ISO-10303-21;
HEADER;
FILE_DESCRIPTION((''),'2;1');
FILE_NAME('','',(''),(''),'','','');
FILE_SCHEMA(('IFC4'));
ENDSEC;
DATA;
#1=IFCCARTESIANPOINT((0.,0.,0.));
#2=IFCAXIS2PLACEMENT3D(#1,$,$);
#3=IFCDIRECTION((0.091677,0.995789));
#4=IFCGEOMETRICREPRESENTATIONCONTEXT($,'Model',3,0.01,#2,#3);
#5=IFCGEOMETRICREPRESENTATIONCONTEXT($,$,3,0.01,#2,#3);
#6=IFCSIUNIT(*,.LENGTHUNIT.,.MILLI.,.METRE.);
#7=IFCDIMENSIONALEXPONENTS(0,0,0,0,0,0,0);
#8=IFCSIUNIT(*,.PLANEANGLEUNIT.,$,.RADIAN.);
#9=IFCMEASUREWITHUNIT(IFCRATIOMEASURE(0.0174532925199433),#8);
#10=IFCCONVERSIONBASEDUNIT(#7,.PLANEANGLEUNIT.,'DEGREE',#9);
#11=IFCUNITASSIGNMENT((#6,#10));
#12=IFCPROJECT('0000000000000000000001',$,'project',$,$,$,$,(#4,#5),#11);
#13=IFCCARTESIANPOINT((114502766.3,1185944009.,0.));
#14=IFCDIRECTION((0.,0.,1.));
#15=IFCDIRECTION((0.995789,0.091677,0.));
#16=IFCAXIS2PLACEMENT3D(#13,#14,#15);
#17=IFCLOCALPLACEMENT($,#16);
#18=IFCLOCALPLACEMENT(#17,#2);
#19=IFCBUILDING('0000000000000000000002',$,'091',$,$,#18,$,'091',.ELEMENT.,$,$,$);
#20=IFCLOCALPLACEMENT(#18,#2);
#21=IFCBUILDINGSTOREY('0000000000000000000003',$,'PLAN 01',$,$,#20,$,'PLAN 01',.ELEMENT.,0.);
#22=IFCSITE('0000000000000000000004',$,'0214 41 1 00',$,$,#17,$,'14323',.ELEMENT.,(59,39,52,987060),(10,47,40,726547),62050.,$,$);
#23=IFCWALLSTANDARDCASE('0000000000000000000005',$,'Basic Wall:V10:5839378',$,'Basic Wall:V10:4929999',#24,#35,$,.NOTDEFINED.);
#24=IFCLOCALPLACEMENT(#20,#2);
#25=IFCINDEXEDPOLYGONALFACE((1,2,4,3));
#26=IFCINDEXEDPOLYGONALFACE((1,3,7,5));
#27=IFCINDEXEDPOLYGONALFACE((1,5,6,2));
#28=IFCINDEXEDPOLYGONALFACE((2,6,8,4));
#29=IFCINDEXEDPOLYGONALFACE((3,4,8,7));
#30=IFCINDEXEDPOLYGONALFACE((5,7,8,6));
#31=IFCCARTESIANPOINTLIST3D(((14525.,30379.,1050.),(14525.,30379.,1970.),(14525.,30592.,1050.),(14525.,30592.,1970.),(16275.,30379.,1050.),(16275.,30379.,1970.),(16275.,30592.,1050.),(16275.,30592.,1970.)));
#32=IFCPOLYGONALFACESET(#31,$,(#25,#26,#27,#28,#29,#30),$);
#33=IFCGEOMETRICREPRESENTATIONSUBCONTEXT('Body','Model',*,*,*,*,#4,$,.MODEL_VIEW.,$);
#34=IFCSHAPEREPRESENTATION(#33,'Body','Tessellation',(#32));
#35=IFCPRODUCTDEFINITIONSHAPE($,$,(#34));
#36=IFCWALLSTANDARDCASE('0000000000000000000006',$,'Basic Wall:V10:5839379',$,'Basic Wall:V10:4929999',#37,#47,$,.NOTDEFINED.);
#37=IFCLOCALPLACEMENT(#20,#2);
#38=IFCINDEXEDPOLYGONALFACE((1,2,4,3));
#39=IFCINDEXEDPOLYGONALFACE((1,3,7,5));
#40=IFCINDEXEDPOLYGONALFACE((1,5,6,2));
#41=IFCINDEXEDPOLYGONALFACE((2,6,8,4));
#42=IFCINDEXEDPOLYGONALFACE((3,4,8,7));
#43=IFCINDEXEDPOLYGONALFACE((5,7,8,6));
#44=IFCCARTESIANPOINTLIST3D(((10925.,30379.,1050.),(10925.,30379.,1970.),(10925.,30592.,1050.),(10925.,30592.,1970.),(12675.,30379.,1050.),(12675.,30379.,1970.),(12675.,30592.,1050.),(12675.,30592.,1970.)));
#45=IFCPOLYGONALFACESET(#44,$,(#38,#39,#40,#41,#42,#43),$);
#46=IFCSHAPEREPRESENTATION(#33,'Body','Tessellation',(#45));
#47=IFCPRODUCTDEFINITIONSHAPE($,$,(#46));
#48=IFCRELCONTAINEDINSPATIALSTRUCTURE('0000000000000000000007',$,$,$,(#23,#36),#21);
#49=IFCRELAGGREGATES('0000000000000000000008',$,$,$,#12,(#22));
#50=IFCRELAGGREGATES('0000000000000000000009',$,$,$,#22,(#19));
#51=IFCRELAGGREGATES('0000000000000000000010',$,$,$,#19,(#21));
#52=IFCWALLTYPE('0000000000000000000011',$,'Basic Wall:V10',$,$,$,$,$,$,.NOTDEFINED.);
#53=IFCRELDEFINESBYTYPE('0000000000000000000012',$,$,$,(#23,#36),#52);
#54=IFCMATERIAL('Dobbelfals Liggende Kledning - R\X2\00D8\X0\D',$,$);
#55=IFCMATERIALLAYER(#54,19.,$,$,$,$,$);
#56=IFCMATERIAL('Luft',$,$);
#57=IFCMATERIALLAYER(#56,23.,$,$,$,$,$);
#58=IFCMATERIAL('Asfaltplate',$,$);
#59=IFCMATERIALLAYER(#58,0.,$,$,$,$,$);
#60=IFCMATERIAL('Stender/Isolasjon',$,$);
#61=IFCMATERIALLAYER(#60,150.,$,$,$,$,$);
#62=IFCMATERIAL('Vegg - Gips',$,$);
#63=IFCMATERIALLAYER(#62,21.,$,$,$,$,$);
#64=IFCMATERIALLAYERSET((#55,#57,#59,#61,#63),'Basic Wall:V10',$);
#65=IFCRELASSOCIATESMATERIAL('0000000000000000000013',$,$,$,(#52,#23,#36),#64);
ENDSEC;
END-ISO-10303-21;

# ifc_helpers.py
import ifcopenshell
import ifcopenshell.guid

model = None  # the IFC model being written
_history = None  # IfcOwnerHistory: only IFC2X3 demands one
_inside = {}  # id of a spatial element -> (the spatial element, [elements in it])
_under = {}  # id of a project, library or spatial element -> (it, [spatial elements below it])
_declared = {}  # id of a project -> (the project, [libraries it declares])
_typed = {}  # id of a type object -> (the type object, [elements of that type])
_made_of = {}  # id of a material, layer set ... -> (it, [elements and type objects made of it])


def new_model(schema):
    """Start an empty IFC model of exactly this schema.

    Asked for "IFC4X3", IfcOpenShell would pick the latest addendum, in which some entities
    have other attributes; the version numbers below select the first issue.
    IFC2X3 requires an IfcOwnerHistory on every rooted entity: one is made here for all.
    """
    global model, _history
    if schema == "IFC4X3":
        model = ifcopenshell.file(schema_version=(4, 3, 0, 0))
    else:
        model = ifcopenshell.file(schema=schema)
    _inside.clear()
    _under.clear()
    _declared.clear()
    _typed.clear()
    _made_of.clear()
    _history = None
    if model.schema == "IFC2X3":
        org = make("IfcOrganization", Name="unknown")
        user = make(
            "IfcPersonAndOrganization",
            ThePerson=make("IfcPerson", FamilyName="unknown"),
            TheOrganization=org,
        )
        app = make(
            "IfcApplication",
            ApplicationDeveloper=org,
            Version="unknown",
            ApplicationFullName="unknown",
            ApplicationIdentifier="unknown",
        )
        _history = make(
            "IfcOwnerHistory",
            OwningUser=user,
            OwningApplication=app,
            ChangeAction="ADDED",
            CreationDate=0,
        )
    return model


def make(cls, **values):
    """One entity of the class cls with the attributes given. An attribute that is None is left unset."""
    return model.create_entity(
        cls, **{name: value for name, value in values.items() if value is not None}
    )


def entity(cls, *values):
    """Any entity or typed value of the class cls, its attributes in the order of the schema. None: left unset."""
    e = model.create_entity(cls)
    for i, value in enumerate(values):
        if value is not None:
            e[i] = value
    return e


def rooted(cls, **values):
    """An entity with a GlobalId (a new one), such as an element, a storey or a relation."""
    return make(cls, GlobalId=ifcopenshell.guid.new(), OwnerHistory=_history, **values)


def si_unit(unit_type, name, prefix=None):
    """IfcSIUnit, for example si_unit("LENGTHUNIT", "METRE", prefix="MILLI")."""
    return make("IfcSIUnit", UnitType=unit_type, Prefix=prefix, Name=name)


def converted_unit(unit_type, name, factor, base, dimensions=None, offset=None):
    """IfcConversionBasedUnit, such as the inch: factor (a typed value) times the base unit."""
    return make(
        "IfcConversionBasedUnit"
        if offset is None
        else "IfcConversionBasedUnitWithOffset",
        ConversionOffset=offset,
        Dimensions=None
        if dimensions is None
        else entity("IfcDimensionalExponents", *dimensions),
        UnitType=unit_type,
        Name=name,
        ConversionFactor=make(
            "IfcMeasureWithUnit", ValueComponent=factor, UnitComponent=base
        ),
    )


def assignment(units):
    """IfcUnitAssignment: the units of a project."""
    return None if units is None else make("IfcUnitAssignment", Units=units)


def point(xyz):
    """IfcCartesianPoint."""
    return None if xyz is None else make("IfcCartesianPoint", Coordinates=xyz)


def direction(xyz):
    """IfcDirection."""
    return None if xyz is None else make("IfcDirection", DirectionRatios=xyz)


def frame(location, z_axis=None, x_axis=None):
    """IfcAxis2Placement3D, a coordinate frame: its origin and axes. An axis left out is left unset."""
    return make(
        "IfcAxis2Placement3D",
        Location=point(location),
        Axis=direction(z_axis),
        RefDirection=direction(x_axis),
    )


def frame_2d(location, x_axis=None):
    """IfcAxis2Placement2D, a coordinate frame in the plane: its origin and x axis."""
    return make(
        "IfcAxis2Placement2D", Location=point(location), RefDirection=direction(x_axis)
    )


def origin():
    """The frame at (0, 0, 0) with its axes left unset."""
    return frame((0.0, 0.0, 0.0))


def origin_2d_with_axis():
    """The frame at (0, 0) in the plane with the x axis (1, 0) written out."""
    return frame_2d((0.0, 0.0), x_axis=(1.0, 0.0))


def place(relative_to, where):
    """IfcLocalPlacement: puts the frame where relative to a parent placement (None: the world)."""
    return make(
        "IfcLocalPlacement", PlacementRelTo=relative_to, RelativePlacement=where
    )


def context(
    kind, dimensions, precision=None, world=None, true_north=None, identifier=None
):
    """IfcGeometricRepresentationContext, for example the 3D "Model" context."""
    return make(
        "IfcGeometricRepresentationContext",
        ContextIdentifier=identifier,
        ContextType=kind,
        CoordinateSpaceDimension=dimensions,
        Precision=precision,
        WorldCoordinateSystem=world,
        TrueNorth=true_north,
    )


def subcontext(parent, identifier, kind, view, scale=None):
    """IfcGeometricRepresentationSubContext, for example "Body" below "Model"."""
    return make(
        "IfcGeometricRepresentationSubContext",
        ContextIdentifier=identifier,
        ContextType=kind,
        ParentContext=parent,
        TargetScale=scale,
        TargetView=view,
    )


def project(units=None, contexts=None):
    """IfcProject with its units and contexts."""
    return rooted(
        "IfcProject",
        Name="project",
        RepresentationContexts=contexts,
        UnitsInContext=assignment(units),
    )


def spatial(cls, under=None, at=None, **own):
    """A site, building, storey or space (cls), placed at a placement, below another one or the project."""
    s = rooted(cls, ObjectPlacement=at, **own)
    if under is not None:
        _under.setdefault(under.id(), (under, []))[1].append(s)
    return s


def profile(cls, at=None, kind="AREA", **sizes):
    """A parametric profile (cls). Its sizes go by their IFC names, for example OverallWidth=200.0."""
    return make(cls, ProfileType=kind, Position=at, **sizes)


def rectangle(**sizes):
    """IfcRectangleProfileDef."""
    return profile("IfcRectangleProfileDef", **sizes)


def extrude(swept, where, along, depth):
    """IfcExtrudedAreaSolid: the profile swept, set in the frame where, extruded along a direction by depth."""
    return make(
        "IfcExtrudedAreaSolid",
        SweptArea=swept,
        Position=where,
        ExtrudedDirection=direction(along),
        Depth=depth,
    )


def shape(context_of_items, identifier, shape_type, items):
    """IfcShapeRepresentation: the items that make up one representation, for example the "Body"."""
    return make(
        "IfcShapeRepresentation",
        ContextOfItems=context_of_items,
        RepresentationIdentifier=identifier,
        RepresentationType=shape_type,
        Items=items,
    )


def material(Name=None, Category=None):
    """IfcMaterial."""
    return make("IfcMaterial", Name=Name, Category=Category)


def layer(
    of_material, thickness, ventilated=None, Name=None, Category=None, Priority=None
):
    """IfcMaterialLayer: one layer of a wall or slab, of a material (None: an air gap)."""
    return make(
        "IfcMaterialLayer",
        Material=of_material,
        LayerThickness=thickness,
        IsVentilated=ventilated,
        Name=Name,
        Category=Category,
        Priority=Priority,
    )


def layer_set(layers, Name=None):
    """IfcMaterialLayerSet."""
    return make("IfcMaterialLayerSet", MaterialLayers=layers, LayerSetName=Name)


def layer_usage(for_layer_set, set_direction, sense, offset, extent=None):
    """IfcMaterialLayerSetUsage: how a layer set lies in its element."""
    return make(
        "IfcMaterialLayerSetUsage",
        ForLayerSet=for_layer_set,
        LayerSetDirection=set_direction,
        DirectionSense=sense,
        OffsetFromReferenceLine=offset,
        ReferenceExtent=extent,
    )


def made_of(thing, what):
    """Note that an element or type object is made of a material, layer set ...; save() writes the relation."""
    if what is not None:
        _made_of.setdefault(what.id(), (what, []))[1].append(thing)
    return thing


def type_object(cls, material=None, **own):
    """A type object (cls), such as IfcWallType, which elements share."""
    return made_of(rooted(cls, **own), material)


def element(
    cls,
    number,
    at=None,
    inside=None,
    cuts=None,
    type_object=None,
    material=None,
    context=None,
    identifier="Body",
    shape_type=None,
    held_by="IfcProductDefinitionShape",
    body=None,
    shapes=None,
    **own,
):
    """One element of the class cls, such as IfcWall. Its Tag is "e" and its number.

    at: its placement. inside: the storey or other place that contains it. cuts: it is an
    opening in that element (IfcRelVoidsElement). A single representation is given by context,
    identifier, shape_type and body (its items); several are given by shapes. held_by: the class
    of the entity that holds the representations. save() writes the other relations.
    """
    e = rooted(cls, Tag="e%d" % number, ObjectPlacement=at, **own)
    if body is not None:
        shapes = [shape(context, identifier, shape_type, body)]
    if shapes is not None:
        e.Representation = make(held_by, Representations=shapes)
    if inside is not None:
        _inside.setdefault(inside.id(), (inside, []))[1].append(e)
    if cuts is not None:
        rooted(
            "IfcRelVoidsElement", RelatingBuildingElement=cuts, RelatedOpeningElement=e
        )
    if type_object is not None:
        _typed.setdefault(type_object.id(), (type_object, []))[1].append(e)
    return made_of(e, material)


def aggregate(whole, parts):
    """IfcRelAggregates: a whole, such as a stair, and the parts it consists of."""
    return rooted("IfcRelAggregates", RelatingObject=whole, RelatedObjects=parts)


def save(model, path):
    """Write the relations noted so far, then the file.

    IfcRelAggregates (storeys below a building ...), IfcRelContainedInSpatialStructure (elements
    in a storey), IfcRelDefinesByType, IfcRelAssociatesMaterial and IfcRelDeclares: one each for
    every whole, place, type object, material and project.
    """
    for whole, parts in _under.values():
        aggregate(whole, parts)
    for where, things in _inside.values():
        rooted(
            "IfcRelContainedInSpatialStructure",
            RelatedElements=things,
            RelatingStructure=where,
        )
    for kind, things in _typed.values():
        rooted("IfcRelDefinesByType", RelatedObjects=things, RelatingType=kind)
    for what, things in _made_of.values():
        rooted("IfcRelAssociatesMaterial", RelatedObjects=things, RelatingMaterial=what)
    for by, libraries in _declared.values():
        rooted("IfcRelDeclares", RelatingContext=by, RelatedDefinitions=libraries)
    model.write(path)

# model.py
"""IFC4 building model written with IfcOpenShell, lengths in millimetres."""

from ifc_helpers import new_model, entity, si_unit, converted_unit, direction, frame, frame_2d, origin, origin_2d_with_axis, place, context, subcontext, project, spatial, rectangle, extrude, material, layer, layer_set, layer_usage, type_object, element, save


model = new_model("IFC4")

# Units and contexts
model_context = context("Model", 3, precision=0.01, world=origin(), true_north=direction((0.091677, 0.995789)))
context_of_model = context(None, 3, precision=0.01, world=origin(), true_north=direction((0.091677, 0.995789)))
body_context = subcontext(model_context, "Body", "Model", "MODEL_VIEW")
ifc_project = project(units=[si_unit("LENGTHUNIT", "METRE", prefix="MILLI"), converted_unit("PLANEANGLEUNIT", "DEGREE", entity("IfcRatioMeasure", 0.0174532925199433), si_unit("PLANEANGLEUNIT", "RADIAN"), dimensions=[0, 0, 0, 0, 0, 0, 0])], contexts=[model_context, context_of_model])

# Site, building, storey
site_placement = place(None, frame((114502766.3, 1185944009.0, 0.0), z_axis=(0.0, 0.0, 1.0), x_axis=(0.995789, 0.091677, 0.0)))
site = spatial("IfcSite", under=ifc_project, at=site_placement, Name="0214 41 1 00", LongName="14323", CompositionType="ELEMENT", RefLatitude=(59, 39, 52, 987060), RefLongitude=(10, 47, 40, 726547), RefElevation=62050.0)
building_placement = place(site_placement, origin())
building = spatial("IfcBuilding", under=site, at=building_placement, Name="091", LongName="091", CompositionType="ELEMENT")
storey_placement = place(building_placement, origin())
storey = spatial("IfcBuildingStorey", under=building, at=storey_placement, Name="PLAN 01", LongName="PLAN 01", CompositionType="ELEMENT", Elevation=0.0)

# Shared definitions
ifc_material_1 = material(Name="Dobbelfals Liggende Kledning - RØD")
ifc_layer_1 = layer(ifc_material_1, 19.0)
ifc_material_2 = material(Name="Luft")
ifc_layer_2 = layer(ifc_material_2, 23.0)
ifc_material_3 = material(Name="Asfaltplate")
ifc_layer_3 = layer(ifc_material_3, 0.0)
ifc_material_4 = material(Name="Stender/Isolasjon")
ifc_layer_4 = layer(ifc_material_4, 150.0)
ifc_material_5 = material(Name="Vegg - Gips")
ifc_layer_5 = layer(ifc_material_5, 21.0)
ifc_layer_set = layer_set([ifc_layer_1, ifc_layer_2, ifc_layer_3, ifc_layer_4, ifc_layer_5], Name="Basic Wall:V10")
wall_type = type_object("IfcWallType", Name="Basic Wall:V10", PredefinedType="NOTDEFINED", material=ifc_layer_set)

# Walls
ifc_layer_usage_1 = layer_usage(ifc_layer_set, "AXIS2", "NEGATIVE", 106.5)
wall_1_placement = place(storey_placement, frame((14525.0, 30485.5, 1050.0)))
element("IfcWallStandardCase", 1, at=wall_1_placement, inside=storey, type_object=wall_type, material=ifc_layer_usage_1, Name="Basic Wall:V10:5839378", ObjectType="Basic Wall:V10:4929999", PredefinedType="NOTDEFINED", context=body_context, shape_type="SweptSolid", body=[
    extrude(rectangle(XDim=1750.0, YDim=213.0, at=frame_2d((0.0, 0.0), x_axis=(1.0, 0.0))), frame((875.0, 0.0, 0.0), z_axis=(0.0, 0.0, 1.0), x_axis=(-1.0, 0.0, 0.0)), (0.0, 0.0, 1.0), 920.0),
])
ifc_layer_usage_2 = layer_usage(ifc_layer_set, "AXIS2", "NEGATIVE", 106.5)
wall_2_placement = place(storey_placement, frame((10925.0, 30485.5, 1050.0)))
element("IfcWallStandardCase", 2, at=wall_2_placement, inside=storey, type_object=wall_type, material=ifc_layer_usage_2, Name="Basic Wall:V10:5839379", ObjectType="Basic Wall:V10:4929999", PredefinedType="NOTDEFINED", context=body_context, shape_type="SweptSolid", body=[
    extrude(rectangle(XDim=1750.0, YDim=213.0, at=origin_2d_with_axis()), frame((875.0, 0.0, 0.0), z_axis=(0.0, 0.0, 1.0), x_axis=(-1.0, 0.0, 0.0)), (0.0, 0.0, 1.0), 920.0),
])

save(model, "model.ifc")
